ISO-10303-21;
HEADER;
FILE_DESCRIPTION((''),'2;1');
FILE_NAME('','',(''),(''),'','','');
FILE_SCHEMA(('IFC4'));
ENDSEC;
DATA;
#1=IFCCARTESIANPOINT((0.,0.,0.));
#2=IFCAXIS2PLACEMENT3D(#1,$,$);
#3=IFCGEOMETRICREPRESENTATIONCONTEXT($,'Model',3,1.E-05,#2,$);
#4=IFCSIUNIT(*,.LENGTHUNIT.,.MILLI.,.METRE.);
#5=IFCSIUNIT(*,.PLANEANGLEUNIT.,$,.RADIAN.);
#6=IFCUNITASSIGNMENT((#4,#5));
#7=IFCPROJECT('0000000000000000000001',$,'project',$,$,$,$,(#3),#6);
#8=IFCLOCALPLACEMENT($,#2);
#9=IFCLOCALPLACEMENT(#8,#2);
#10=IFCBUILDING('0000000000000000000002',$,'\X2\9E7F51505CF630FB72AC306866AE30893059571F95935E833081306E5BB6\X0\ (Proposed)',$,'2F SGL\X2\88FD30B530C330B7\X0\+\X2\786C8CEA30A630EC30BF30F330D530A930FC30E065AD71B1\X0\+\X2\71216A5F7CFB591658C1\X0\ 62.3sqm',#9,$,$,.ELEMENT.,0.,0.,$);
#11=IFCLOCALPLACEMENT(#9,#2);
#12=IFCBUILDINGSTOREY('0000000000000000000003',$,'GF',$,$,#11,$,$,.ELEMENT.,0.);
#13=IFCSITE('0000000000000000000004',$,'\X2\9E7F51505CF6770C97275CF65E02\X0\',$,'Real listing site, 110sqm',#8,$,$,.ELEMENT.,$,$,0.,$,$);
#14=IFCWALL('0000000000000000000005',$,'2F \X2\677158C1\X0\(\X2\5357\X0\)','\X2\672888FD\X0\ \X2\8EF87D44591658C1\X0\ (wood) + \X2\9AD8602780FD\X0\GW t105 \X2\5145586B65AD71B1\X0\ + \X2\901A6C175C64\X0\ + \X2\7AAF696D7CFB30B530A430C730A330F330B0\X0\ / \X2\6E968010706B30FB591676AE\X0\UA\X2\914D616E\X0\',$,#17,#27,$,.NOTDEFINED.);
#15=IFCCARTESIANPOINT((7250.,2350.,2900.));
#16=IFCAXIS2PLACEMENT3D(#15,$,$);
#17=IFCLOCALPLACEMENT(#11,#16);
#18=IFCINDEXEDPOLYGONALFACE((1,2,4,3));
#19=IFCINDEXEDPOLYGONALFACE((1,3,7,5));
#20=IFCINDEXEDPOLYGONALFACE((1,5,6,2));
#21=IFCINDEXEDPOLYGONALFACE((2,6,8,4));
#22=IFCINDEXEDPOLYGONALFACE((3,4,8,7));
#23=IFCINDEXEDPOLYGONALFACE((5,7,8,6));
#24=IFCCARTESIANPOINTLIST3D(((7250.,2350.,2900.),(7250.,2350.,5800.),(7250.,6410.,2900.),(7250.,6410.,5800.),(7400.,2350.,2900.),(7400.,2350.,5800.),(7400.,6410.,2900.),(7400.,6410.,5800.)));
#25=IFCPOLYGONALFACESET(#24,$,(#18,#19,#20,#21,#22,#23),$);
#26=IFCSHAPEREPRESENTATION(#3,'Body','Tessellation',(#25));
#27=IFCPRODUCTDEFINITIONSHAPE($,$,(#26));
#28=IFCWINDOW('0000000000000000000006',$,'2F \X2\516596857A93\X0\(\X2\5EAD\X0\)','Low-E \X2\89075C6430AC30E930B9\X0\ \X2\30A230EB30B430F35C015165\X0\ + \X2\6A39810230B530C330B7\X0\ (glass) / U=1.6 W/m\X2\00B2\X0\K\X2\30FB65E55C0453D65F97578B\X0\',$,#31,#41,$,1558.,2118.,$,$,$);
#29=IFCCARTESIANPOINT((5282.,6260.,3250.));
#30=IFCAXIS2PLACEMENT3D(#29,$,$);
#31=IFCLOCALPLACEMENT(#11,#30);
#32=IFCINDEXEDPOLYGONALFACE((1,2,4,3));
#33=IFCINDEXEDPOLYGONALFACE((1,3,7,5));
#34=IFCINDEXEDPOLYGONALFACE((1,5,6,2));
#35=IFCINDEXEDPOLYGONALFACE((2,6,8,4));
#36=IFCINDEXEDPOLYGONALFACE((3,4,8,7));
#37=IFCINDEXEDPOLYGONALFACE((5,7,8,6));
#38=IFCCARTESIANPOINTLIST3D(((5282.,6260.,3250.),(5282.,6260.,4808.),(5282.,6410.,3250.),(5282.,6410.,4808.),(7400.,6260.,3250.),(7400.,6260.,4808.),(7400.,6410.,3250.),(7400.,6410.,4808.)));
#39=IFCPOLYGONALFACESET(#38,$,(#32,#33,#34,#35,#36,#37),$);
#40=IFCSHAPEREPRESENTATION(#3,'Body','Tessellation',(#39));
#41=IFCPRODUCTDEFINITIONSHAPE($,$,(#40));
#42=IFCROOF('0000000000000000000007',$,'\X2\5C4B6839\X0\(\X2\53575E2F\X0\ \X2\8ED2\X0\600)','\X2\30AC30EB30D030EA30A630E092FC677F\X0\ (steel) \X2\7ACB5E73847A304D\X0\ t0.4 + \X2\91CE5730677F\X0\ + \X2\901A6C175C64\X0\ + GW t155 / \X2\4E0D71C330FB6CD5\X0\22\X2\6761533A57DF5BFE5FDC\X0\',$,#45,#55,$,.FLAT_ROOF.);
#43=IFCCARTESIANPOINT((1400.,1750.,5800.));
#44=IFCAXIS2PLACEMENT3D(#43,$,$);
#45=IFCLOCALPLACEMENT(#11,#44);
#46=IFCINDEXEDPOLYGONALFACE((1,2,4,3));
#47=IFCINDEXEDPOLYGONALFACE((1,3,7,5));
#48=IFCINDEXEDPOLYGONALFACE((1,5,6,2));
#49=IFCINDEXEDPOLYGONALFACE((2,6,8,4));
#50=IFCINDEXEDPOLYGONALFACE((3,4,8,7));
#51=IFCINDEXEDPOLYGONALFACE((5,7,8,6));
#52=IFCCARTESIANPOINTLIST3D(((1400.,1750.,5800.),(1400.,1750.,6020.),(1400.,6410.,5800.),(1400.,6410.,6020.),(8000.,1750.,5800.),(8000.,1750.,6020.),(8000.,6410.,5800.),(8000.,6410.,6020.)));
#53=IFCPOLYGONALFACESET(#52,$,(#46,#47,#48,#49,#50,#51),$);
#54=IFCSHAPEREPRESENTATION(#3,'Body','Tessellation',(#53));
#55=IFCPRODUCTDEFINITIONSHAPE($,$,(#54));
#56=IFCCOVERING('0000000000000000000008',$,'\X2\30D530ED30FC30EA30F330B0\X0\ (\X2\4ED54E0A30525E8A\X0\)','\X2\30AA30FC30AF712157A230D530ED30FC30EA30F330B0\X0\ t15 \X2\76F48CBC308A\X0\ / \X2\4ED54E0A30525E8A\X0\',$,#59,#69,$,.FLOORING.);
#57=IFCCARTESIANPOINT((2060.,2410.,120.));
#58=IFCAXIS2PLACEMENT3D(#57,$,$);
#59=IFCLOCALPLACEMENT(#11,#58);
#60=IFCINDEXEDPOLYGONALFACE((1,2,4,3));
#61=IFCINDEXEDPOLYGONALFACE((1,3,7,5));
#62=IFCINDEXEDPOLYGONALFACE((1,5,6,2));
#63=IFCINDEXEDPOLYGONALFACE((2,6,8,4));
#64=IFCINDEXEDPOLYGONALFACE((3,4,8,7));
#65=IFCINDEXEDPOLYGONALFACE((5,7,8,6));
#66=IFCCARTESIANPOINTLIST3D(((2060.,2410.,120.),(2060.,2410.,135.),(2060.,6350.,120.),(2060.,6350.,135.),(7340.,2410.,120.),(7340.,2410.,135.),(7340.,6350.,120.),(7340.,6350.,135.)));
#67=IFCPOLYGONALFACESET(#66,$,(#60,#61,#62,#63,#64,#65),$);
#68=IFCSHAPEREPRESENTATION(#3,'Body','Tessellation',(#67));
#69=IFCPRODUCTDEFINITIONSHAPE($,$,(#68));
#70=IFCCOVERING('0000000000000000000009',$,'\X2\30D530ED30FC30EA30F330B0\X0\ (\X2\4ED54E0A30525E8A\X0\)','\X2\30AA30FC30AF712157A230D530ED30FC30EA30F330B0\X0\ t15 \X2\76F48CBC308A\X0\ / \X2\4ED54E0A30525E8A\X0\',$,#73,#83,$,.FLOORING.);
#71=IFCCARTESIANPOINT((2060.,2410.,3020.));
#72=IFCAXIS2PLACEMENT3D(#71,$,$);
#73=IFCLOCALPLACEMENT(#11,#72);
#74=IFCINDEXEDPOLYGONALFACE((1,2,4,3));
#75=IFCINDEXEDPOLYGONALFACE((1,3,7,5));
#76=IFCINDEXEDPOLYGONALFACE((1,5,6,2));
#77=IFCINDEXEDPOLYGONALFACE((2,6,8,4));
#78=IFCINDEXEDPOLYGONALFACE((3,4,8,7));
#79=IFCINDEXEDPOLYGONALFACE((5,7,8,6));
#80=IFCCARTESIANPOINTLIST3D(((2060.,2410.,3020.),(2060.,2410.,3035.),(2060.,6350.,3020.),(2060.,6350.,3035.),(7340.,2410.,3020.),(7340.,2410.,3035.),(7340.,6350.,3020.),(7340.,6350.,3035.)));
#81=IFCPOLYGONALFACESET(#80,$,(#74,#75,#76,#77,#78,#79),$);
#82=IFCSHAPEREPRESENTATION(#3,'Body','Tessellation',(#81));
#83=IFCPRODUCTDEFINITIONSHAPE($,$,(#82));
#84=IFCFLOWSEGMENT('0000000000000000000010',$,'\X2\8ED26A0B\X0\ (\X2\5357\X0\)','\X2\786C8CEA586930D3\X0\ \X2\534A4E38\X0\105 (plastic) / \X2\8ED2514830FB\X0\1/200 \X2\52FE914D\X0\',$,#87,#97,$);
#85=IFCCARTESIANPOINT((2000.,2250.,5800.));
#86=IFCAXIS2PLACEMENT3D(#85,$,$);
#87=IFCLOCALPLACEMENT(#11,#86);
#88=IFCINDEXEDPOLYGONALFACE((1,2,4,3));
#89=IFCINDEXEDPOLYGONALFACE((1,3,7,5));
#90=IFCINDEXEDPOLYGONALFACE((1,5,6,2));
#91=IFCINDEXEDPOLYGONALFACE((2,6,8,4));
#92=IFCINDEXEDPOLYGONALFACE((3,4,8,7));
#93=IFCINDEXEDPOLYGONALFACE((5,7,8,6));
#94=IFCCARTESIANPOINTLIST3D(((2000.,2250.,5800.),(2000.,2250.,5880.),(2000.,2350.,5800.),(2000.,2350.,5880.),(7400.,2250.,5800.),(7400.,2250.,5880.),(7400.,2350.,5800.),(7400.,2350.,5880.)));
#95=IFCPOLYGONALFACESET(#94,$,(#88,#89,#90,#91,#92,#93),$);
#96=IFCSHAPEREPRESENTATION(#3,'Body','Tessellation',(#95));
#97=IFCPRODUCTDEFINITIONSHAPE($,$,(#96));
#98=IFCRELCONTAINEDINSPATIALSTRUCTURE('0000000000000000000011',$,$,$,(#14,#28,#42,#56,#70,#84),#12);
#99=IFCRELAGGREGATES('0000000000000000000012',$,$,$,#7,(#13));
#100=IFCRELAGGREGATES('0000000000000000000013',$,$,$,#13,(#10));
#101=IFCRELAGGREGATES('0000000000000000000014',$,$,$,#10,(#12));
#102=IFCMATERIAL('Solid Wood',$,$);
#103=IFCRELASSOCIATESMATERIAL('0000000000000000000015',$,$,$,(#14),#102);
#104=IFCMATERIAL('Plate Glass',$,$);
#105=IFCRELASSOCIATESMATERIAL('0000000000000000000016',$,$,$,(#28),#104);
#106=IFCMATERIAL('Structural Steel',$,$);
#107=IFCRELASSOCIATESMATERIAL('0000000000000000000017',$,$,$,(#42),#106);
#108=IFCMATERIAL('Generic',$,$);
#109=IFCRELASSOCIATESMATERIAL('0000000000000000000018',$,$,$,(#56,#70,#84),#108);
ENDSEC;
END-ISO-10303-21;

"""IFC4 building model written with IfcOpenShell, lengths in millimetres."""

from ifc_helpers import new_model, si_unit, frame, frame_2d, origin, place, context, project, spatial, rectangle, extrude, material, element, fill, save


model = new_model("IFC4")

# Units and contexts
model_context = context("Model", 3, precision=1e-05, world=origin())
ifc_project = project(units=[si_unit("LENGTHUNIT", "METRE", prefix="MILLI"), si_unit("PLANEANGLEUNIT", "RADIAN")], contexts=[model_context])

# Site, building, storey
site_placement = place(None, origin())
site = spatial("IfcSite", under=ifc_project, at=site_placement, Name="鹿児島県霧島市", ObjectType="Real listing site, 110sqm", CompositionType="ELEMENT", RefElevation=0.0)
building_placement = place(site_placement, origin())
building = spatial("IfcBuilding", under=site, at=building_placement, Name="鹿児島・犬と暮らす土間広めの家 (Proposed)", ObjectType="2F SGL製サッシ+硬質ウレタンフォーム断熱+無機系外壁 62.3sqm", CompositionType="ELEMENT", ElevationOfRefHeight=0.0, ElevationOfTerrain=0.0)
storey_placement = place(building_placement, origin())
storey = spatial("IfcBuildingStorey", under=building, at=storey_placement, Name="GF", CompositionType="ELEMENT", Elevation=0.0)

# Shared definitions
ifc_material_1 = material(Name="Solid Wood")

# Wall, opening, window
ifc_material_2 = material(Name="Plate Glass")
wall_1_placement = place(storey_placement, frame((7250.0, 2350.0, 2900.0)))
wall_1 = element("IfcWall", 1, at=wall_1_placement, inside=storey, material=ifc_material_1, Name="2F 東壁(南)", Description="木製 軸組外壁 (wood) + 高性能GW t105 充填断熱 + 通気層 + 窯業系サイディング / 準耐火・外皮UA配慮", PredefinedType="NOTDEFINED", context=model_context, shape_type="SweptSolid", body=[
    extrude(rectangle(XDim=150.0, YDim=4060.0, at=frame_2d((75.0, 2030.0))), frame((7250.0, 2350.0, 2900.0)), (0.0, 0.0, 1.0), 2900.0),
])
opening_1_placement = place(storey_placement, frame((5282.0, 6260.0, 3250.0)))
opening_1 = element("IfcOpeningElement", 2, at=opening_1_placement, cuts=wall_1, PredefinedType="NOTDEFINED", context=model_context, shape_type="SweptSolid", body=[
    extrude(rectangle(XDim=2118.0, YDim=150.0, at=frame_2d((1059.0, 75.0))), frame((5282.0, 6260.0, 3250.0)), (0.0, 0.0, 1.0), 1558.0),
])
window_1_placement = place(storey_placement, frame((5282.0, 6260.0, 3250.0)))
window_1 = element("IfcWindow", 3, at=window_1_placement, inside=storey, material=ifc_material_2, Name="2F 入隅窓(庭)", Description="Low-E 複層ガラス アルゴン封入 + 樹脂サッシ (glass) / U=1.6 W/m²K・日射取得型", OverallHeight=1558.0, OverallWidth=2118.0, context=model_context, shape_type="SweptSolid", body=[
    extrude(rectangle(XDim=2118.0, YDim=150.0, at=frame_2d((1059.0, 75.0))), frame((5282.0, 6260.0, 3250.0)), (0.0, 0.0, 1.0), 1558.0),
])
fill(opening_1, window_1)

# Roof
ifc_material_3 = material(Name="Structural Steel")
for number, where, name in (
    (4, (1400.0, 1750.0, 5800.0), "屋根(南帯 軒600)"),
):
    element("IfcRoof", number, at=place(storey_placement, frame(where)), inside=storey, material=ifc_material_3, Name=name, Description="ガルバリウム鋼板 (steel) 立平葺き t0.4 + 野地板 + 通気層 + GW t155 / 不燃・法22条区域対応", PredefinedType="FLAT_ROOF", context=model_context, shape_type="SweptSolid", body=[
        extrude(rectangle(XDim=6600.0, YDim=4660.0, at=frame_2d((3300.0, 2330.0))), frame((1400.0, 1750.0, 5800.0)), (0.0, 0.0, 1.0), 220.0),
    ])

# Coverings
ifc_material_4 = material(Name="Generic")
covering_1_placement = place(storey_placement, frame((2060.0, 2410.0, 120.0)))
element("IfcCovering", 5, at=covering_1_placement, inside=storey, material=ifc_material_4, Name="フローリング (仕上げ床)", Description="オーク無垢フローリング t15 直貼り / 仕上げ床", PredefinedType="FLOORING", context=model_context, shape_type="SweptSolid", body=[
    extrude(rectangle(XDim=5280.0, YDim=3940.0, at=frame_2d((2640.0, 1970.0))), frame((2060.0, 2410.0, 120.0)), (0.0, 0.0, 1.0), 15.0),
])
covering_2_placement = place(storey_placement, frame((2060.0, 2410.0, 3020.0)))
element("IfcCovering", 6, at=covering_2_placement, inside=storey, material=ifc_material_4, Name="フローリング (仕上げ床)", Description="オーク無垢フローリング t15 直貼り / 仕上げ床", PredefinedType="FLOORING", context=model_context, shape_type="SweptSolid", body=[
    extrude(rectangle(XDim=5280.0, YDim=3940.0, at=frame_2d((2640.0, 1970.0))), frame((2060.0, 2410.0, 3020.0)), (0.0, 0.0, 1.0), 15.0),
])

# Flow segment
flow_segment_placement = place(storey_placement, frame((2000.0, 2250.0, 5800.0)))
element("IfcFlowSegment", 7, at=flow_segment_placement, inside=storey, material=ifc_material_4, Name="軒樋 (南)", Description="硬質塩ビ 半丸105 (plastic) / 軒先・1/200 勾配", context=model_context, shape_type="SweptSolid", body=[
    extrude(rectangle(XDim=5400.0, YDim=100.0, at=frame_2d((2700.0, 50.0))), frame((2000.0, 2250.0, 5800.0)), (0.0, 0.0, 1.0), 80.0),
])

save(model, "model.ifc")
